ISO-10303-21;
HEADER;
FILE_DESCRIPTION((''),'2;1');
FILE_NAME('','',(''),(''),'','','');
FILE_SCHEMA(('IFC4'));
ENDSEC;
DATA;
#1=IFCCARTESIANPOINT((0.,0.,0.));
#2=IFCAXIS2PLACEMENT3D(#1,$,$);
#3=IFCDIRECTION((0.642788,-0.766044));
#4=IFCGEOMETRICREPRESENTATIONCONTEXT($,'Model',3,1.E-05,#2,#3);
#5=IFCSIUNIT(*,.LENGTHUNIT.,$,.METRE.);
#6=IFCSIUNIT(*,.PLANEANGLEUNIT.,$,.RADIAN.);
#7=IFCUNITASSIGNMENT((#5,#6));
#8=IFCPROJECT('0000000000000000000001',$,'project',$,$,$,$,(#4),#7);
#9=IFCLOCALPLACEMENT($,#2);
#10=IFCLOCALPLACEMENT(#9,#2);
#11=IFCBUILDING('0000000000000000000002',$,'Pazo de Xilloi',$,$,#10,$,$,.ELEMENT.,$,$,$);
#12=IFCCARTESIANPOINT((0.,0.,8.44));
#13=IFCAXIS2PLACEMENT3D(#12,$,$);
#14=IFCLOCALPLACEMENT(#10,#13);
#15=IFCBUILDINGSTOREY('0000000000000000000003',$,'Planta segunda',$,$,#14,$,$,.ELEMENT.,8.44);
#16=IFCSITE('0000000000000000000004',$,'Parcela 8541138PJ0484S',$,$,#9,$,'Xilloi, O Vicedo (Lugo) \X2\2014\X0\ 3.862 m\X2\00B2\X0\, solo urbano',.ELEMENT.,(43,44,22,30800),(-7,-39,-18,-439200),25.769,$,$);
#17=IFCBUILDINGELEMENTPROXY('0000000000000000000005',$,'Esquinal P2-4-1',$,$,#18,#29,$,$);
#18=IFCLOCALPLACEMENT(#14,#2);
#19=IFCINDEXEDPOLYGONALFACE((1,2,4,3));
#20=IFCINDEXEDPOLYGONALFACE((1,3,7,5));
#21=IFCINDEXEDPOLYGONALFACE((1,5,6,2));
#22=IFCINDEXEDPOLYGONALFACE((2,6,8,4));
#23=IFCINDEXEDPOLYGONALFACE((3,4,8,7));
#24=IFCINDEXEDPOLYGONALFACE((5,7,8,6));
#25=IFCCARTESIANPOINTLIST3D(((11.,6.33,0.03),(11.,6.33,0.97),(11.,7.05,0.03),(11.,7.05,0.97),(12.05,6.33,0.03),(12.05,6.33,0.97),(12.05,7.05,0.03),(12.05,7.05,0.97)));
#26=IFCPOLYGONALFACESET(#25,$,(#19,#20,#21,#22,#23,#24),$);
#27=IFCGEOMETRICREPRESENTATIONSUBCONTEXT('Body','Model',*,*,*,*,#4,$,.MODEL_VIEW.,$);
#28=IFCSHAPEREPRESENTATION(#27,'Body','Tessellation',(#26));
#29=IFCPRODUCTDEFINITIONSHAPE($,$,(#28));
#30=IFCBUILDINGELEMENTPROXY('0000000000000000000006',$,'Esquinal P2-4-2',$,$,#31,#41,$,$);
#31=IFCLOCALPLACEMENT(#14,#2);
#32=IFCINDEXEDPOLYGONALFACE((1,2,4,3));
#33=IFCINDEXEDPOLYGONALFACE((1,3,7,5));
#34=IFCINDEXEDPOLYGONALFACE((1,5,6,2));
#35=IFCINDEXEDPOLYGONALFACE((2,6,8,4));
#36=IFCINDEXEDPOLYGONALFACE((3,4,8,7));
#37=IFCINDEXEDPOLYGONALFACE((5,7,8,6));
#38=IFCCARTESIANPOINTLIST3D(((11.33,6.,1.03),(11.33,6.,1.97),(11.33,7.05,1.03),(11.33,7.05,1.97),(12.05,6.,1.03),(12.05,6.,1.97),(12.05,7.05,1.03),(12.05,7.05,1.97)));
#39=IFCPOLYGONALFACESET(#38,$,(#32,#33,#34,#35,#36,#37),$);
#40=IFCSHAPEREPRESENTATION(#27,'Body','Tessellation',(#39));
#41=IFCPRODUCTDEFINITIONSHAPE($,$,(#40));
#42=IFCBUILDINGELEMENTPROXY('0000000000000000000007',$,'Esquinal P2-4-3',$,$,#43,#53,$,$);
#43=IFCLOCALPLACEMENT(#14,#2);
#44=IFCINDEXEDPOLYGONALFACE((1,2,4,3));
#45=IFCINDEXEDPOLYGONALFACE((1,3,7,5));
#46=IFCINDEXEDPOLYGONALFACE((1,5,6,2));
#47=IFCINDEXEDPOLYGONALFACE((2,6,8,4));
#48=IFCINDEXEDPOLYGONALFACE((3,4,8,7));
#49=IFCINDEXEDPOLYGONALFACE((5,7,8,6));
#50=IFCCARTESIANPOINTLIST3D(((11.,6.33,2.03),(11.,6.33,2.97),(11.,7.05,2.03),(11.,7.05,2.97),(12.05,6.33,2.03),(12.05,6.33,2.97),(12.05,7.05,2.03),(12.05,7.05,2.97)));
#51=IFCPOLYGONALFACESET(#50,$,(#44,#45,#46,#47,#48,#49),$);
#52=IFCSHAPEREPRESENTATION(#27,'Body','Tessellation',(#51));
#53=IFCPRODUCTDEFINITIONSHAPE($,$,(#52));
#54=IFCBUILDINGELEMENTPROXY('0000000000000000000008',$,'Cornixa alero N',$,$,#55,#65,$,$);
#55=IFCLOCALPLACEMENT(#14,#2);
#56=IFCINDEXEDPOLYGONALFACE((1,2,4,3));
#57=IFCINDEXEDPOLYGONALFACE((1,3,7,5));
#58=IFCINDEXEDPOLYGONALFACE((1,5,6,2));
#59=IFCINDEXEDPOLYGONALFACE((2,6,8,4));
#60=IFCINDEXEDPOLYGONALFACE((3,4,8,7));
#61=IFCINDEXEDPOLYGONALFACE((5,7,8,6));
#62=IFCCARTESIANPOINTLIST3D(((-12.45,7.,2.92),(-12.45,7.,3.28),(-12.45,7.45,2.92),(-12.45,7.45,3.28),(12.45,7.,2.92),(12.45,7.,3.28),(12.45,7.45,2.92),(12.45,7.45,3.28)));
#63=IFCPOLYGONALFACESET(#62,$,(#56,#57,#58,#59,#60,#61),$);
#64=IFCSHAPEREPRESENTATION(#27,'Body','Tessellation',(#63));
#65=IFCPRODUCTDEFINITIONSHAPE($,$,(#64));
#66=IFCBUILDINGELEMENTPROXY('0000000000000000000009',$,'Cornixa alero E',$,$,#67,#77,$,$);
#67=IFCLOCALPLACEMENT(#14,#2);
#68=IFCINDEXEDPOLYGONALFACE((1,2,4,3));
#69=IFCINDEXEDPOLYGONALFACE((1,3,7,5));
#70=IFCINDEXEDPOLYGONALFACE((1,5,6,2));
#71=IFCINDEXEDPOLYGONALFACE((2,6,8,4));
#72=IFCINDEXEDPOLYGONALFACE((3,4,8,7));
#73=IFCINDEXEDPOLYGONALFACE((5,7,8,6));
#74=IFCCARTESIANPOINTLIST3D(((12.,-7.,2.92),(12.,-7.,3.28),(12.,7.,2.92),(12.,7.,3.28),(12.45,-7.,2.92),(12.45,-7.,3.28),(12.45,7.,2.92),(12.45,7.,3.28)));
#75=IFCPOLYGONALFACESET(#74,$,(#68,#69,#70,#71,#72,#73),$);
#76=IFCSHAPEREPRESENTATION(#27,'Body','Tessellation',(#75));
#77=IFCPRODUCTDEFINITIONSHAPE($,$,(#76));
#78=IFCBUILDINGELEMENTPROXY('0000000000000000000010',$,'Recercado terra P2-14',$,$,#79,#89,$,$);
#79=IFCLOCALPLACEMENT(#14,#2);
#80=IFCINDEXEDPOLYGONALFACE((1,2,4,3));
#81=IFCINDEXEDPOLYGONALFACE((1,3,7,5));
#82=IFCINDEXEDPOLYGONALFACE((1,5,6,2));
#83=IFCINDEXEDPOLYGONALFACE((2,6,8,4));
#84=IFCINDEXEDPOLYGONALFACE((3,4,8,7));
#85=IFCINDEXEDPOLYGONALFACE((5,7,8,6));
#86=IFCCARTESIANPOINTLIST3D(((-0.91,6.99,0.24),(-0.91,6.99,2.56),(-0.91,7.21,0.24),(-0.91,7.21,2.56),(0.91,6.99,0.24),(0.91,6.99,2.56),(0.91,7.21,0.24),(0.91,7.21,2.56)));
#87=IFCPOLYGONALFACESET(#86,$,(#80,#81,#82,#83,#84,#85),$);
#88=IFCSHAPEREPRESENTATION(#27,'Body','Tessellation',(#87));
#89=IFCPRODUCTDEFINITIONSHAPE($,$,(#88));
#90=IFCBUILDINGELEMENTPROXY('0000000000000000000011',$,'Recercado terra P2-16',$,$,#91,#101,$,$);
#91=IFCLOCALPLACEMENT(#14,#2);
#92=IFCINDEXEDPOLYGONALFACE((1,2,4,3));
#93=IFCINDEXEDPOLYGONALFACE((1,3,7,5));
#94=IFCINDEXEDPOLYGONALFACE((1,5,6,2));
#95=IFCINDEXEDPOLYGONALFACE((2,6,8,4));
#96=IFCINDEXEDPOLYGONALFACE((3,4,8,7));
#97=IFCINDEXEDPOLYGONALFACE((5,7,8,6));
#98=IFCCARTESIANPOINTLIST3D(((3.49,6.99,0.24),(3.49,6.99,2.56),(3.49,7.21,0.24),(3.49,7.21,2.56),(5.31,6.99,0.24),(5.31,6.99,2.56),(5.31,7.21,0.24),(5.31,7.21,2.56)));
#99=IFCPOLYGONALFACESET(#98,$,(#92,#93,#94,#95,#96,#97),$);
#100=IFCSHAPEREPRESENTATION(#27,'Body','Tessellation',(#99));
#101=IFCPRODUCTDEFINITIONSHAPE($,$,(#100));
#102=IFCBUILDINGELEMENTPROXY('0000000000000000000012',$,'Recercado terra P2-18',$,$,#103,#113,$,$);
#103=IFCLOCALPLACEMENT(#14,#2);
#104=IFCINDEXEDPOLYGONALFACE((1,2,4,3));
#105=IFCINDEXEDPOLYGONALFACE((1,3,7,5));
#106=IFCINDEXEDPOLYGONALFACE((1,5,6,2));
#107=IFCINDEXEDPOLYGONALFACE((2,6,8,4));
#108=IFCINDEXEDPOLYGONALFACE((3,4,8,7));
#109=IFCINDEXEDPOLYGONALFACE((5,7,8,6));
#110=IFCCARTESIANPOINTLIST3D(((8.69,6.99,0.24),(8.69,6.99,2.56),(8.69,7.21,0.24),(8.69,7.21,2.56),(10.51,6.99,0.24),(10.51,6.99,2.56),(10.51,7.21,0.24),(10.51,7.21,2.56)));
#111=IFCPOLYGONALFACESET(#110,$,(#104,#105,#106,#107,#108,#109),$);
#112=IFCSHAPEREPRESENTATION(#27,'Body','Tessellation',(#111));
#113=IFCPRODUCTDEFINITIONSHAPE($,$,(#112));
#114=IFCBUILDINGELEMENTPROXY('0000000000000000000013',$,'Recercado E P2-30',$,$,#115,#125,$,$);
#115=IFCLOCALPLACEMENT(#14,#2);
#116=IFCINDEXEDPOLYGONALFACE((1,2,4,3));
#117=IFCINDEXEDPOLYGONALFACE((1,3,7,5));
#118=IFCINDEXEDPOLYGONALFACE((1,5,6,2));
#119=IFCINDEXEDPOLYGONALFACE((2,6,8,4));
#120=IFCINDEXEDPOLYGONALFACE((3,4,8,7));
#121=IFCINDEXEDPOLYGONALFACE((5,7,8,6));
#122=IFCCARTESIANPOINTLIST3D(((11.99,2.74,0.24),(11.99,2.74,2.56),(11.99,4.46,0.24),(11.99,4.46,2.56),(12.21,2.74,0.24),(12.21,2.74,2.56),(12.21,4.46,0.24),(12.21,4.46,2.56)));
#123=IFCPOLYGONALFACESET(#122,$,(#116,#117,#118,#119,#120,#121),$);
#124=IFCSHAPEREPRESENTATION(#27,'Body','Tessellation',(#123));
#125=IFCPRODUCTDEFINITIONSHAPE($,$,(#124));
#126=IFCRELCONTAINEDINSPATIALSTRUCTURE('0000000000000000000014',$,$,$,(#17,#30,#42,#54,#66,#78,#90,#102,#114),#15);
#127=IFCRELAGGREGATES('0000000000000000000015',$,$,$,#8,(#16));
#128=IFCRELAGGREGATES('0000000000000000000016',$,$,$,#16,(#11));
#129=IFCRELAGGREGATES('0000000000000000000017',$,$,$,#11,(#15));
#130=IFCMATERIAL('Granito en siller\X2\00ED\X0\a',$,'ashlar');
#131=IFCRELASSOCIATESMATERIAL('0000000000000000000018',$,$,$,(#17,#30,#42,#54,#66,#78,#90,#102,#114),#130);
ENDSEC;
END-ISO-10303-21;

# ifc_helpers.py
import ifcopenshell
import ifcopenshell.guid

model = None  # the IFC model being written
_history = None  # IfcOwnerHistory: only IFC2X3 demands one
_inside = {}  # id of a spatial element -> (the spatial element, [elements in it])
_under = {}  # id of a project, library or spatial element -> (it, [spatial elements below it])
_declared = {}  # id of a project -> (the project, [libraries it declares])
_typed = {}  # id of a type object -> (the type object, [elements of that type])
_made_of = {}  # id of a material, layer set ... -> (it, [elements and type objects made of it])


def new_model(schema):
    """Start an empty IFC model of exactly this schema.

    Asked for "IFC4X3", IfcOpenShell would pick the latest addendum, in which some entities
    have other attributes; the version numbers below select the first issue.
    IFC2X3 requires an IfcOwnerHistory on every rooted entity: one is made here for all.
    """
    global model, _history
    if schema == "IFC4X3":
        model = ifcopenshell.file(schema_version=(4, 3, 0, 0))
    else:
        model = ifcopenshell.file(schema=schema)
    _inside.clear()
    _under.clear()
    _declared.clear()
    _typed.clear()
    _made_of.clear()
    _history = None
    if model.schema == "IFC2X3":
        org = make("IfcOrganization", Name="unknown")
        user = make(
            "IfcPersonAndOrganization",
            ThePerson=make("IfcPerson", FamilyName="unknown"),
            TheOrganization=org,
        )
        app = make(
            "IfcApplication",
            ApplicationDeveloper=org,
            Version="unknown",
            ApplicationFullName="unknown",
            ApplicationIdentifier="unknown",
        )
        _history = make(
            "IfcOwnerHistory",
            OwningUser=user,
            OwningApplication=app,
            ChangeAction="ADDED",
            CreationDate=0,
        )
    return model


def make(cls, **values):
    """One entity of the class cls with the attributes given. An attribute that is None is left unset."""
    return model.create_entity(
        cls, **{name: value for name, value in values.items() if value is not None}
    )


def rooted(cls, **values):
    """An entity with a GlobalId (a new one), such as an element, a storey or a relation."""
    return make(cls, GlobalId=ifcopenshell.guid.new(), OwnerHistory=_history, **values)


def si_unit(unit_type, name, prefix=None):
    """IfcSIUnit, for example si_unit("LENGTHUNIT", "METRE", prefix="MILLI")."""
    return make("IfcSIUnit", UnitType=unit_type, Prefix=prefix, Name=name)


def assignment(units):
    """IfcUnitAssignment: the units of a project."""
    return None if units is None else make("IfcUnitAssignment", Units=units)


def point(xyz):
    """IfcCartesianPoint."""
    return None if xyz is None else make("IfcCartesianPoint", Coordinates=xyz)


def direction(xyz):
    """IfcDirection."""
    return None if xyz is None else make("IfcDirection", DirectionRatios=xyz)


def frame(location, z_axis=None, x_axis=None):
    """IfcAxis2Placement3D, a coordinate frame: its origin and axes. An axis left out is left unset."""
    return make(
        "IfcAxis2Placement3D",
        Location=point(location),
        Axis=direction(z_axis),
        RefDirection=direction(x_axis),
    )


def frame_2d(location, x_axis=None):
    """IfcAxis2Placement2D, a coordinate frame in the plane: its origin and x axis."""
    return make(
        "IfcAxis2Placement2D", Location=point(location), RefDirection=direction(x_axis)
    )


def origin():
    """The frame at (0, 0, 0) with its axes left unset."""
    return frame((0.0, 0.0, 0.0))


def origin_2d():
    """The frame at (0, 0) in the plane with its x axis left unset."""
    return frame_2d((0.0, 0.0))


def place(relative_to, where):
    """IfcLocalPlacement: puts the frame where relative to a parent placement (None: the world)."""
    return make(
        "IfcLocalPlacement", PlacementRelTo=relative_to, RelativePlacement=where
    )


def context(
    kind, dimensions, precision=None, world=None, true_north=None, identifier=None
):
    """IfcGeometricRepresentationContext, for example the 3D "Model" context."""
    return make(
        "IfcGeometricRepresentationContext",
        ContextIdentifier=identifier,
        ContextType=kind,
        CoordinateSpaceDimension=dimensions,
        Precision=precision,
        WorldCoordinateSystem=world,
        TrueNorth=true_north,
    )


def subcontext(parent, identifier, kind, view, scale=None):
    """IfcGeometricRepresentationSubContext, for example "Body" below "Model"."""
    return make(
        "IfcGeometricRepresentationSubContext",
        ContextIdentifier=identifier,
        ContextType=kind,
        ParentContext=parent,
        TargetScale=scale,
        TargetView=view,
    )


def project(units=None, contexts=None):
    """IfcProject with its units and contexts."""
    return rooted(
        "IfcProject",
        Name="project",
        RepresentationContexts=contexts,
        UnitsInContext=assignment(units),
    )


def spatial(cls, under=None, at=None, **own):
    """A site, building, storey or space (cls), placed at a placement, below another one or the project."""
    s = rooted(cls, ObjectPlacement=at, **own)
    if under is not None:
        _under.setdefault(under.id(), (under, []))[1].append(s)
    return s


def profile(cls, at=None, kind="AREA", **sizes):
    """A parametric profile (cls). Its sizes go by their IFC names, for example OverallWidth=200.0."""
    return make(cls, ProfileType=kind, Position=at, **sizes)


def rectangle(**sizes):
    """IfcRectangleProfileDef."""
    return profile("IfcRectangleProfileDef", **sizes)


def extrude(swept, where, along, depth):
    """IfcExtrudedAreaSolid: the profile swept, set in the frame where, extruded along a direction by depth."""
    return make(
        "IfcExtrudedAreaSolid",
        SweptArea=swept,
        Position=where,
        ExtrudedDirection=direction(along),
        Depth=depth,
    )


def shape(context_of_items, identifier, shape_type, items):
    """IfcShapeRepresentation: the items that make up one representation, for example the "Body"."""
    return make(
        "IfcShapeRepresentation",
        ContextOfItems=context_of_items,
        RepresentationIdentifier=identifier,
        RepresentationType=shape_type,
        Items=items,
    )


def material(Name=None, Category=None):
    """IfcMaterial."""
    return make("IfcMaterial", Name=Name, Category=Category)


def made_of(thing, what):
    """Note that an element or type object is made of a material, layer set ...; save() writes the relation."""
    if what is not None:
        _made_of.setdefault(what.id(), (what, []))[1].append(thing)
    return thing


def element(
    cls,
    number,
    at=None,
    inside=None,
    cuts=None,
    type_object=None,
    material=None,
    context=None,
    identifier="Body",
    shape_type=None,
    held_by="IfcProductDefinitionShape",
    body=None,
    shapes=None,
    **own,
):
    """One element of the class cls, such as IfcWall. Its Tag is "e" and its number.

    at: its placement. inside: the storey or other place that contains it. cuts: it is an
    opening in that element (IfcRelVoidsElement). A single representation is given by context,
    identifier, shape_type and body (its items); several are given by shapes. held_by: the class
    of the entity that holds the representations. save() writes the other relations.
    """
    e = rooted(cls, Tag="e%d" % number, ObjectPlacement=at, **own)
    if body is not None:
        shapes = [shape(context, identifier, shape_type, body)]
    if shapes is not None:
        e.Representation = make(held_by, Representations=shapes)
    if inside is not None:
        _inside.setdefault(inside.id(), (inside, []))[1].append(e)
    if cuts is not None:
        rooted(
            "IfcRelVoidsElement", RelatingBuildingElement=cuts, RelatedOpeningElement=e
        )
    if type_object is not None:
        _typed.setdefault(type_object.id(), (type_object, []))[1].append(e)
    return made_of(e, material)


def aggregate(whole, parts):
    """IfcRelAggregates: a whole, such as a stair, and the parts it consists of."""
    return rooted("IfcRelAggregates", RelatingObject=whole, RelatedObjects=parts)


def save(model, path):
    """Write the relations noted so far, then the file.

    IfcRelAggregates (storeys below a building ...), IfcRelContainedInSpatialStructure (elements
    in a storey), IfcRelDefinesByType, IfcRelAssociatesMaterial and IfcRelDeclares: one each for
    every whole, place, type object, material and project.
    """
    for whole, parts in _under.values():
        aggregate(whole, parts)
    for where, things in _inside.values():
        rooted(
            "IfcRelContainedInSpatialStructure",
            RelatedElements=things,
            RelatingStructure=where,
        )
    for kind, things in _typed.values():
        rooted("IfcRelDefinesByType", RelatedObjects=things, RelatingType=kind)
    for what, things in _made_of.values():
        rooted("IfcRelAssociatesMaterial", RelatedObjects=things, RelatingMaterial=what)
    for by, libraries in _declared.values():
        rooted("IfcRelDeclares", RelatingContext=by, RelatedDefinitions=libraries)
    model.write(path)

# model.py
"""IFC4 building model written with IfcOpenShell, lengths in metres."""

from ifc_helpers import new_model, si_unit, direction, frame, origin, origin_2d, place, context, subcontext, project, spatial, rectangle, extrude, material, element, save


model = new_model("IFC4")

# Units and contexts
model_context = context("Model", 3, precision=1e-05, world=origin(), true_north=direction((0.642788, -0.766044)))
body_context = subcontext(model_context, "Body", "Model", "MODEL_VIEW")
ifc_project = project(units=[si_unit("LENGTHUNIT", "METRE"), si_unit("PLANEANGLEUNIT", "RADIAN")], contexts=[model_context])

# Site, building, storey
site_placement = place(None, origin())
site = spatial("IfcSite", under=ifc_project, at=site_placement, Name="Parcela 8541138PJ0484S", LongName="Xilloi, O Vicedo (Lugo) — 3.862 m², solo urbano", CompositionType="ELEMENT", RefLatitude=(43, 44, 22, 30800), RefLongitude=(-7, -39, -18, -439200), RefElevation=25.769)
building_placement = place(site_placement, origin())
building = spatial("IfcBuilding", under=site, at=building_placement, Name="Pazo de Xilloi", CompositionType="ELEMENT")
storey_placement = place(building_placement, frame((0.0, 0.0, 8.44)))
storey = spatial("IfcBuildingStorey", under=building, at=storey_placement, Name="Planta segunda", CompositionType="ELEMENT", Elevation=8.44)

# Building element proxies
ifc_material_1 = material(Name="Granito en sillería", Category="ashlar")
proxy_1_placement = place(storey_placement, frame((11.525, 6.69, 0.5)))
element("IfcBuildingElementProxy", 1, at=proxy_1_placement, inside=storey, material=ifc_material_1, Name="Esquinal P2-4-1", context=body_context, shape_type="SweptSolid", body=[
    extrude(rectangle(XDim=1.05, YDim=0.72, at=origin_2d()), frame((0.0, 0.0, -0.47)), (0.0, 0.0, 1.0), 0.94),
])
proxy_2_placement = place(storey_placement, frame((11.69, 6.525, 1.5)))
element("IfcBuildingElementProxy", 2, at=proxy_2_placement, inside=storey, material=ifc_material_1, Name="Esquinal P2-4-2", context=body_context, shape_type="SweptSolid", body=[
    extrude(rectangle(XDim=0.72, YDim=1.05, at=origin_2d()), frame((0.0, 0.0, -0.47)), (0.0, 0.0, 1.0), 0.94),
])
proxy_3_placement = place(storey_placement, frame((11.525, 6.69, 2.5)))
element("IfcBuildingElementProxy", 3, at=proxy_3_placement, inside=storey, material=ifc_material_1, Name="Esquinal P2-4-3", context=body_context, shape_type="SweptSolid", body=[
    extrude(rectangle(XDim=1.05, YDim=0.72, at=origin_2d()), frame((0.0, 0.0, -0.47)), (0.0, 0.0, 1.0), 0.94),
])
proxy_4_placement = place(storey_placement, frame((0.0, 7.225, 3.1)))
element("IfcBuildingElementProxy", 4, at=proxy_4_placement, inside=storey, material=ifc_material_1, Name="Cornixa alero N", context=body_context, shape_type="SweptSolid", body=[
    extrude(rectangle(XDim=24.9, YDim=0.45, at=origin_2d()), frame((0.0, 0.0, -0.18)), (0.0, 0.0, 1.0), 0.36),
])
proxy_5_placement = place(storey_placement, frame((12.225, 0.0, 3.1)))
element("IfcBuildingElementProxy", 5, at=proxy_5_placement, inside=storey, material=ifc_material_1, Name="Cornixa alero E", context=body_context, shape_type="SweptSolid", body=[
    extrude(rectangle(XDim=0.45, YDim=14.0, at=origin_2d()), frame((0.0, 0.0, -0.18)), (0.0, 0.0, 1.0), 0.36),
])
for number, where, name in (
    (6, (0.0, 7.1, 1.4), "Recercado terra P2-14"),
    (7, (4.4, 7.1, 1.4), "Recercado terra P2-16"),
    (8, (9.6, 7.1, 1.4), "Recercado terra P2-18"),
):
    element("IfcBuildingElementProxy", number, at=place(storey_placement, frame(where)), inside=storey, material=ifc_material_1, Name=name, context=body_context, shape_type="SweptSolid", body=[
        extrude(rectangle(XDim=1.82, YDim=0.22, at=origin_2d()), frame((0.0, 0.0, -1.16)), (0.0, 0.0, 1.0), 2.32),
    ])
proxy_6_placement = place(storey_placement, frame((12.1, 3.6, 1.4)))
element("IfcBuildingElementProxy", 9, at=proxy_6_placement, inside=storey, material=ifc_material_1, Name="Recercado E P2-30", context=body_context, shape_type="SweptSolid", body=[
    extrude(rectangle(XDim=0.22, YDim=1.72, at=origin_2d()), frame((0.0, 0.0, -1.16)), (0.0, 0.0, 1.0), 2.32),
])

save(model, "model.ifc")
